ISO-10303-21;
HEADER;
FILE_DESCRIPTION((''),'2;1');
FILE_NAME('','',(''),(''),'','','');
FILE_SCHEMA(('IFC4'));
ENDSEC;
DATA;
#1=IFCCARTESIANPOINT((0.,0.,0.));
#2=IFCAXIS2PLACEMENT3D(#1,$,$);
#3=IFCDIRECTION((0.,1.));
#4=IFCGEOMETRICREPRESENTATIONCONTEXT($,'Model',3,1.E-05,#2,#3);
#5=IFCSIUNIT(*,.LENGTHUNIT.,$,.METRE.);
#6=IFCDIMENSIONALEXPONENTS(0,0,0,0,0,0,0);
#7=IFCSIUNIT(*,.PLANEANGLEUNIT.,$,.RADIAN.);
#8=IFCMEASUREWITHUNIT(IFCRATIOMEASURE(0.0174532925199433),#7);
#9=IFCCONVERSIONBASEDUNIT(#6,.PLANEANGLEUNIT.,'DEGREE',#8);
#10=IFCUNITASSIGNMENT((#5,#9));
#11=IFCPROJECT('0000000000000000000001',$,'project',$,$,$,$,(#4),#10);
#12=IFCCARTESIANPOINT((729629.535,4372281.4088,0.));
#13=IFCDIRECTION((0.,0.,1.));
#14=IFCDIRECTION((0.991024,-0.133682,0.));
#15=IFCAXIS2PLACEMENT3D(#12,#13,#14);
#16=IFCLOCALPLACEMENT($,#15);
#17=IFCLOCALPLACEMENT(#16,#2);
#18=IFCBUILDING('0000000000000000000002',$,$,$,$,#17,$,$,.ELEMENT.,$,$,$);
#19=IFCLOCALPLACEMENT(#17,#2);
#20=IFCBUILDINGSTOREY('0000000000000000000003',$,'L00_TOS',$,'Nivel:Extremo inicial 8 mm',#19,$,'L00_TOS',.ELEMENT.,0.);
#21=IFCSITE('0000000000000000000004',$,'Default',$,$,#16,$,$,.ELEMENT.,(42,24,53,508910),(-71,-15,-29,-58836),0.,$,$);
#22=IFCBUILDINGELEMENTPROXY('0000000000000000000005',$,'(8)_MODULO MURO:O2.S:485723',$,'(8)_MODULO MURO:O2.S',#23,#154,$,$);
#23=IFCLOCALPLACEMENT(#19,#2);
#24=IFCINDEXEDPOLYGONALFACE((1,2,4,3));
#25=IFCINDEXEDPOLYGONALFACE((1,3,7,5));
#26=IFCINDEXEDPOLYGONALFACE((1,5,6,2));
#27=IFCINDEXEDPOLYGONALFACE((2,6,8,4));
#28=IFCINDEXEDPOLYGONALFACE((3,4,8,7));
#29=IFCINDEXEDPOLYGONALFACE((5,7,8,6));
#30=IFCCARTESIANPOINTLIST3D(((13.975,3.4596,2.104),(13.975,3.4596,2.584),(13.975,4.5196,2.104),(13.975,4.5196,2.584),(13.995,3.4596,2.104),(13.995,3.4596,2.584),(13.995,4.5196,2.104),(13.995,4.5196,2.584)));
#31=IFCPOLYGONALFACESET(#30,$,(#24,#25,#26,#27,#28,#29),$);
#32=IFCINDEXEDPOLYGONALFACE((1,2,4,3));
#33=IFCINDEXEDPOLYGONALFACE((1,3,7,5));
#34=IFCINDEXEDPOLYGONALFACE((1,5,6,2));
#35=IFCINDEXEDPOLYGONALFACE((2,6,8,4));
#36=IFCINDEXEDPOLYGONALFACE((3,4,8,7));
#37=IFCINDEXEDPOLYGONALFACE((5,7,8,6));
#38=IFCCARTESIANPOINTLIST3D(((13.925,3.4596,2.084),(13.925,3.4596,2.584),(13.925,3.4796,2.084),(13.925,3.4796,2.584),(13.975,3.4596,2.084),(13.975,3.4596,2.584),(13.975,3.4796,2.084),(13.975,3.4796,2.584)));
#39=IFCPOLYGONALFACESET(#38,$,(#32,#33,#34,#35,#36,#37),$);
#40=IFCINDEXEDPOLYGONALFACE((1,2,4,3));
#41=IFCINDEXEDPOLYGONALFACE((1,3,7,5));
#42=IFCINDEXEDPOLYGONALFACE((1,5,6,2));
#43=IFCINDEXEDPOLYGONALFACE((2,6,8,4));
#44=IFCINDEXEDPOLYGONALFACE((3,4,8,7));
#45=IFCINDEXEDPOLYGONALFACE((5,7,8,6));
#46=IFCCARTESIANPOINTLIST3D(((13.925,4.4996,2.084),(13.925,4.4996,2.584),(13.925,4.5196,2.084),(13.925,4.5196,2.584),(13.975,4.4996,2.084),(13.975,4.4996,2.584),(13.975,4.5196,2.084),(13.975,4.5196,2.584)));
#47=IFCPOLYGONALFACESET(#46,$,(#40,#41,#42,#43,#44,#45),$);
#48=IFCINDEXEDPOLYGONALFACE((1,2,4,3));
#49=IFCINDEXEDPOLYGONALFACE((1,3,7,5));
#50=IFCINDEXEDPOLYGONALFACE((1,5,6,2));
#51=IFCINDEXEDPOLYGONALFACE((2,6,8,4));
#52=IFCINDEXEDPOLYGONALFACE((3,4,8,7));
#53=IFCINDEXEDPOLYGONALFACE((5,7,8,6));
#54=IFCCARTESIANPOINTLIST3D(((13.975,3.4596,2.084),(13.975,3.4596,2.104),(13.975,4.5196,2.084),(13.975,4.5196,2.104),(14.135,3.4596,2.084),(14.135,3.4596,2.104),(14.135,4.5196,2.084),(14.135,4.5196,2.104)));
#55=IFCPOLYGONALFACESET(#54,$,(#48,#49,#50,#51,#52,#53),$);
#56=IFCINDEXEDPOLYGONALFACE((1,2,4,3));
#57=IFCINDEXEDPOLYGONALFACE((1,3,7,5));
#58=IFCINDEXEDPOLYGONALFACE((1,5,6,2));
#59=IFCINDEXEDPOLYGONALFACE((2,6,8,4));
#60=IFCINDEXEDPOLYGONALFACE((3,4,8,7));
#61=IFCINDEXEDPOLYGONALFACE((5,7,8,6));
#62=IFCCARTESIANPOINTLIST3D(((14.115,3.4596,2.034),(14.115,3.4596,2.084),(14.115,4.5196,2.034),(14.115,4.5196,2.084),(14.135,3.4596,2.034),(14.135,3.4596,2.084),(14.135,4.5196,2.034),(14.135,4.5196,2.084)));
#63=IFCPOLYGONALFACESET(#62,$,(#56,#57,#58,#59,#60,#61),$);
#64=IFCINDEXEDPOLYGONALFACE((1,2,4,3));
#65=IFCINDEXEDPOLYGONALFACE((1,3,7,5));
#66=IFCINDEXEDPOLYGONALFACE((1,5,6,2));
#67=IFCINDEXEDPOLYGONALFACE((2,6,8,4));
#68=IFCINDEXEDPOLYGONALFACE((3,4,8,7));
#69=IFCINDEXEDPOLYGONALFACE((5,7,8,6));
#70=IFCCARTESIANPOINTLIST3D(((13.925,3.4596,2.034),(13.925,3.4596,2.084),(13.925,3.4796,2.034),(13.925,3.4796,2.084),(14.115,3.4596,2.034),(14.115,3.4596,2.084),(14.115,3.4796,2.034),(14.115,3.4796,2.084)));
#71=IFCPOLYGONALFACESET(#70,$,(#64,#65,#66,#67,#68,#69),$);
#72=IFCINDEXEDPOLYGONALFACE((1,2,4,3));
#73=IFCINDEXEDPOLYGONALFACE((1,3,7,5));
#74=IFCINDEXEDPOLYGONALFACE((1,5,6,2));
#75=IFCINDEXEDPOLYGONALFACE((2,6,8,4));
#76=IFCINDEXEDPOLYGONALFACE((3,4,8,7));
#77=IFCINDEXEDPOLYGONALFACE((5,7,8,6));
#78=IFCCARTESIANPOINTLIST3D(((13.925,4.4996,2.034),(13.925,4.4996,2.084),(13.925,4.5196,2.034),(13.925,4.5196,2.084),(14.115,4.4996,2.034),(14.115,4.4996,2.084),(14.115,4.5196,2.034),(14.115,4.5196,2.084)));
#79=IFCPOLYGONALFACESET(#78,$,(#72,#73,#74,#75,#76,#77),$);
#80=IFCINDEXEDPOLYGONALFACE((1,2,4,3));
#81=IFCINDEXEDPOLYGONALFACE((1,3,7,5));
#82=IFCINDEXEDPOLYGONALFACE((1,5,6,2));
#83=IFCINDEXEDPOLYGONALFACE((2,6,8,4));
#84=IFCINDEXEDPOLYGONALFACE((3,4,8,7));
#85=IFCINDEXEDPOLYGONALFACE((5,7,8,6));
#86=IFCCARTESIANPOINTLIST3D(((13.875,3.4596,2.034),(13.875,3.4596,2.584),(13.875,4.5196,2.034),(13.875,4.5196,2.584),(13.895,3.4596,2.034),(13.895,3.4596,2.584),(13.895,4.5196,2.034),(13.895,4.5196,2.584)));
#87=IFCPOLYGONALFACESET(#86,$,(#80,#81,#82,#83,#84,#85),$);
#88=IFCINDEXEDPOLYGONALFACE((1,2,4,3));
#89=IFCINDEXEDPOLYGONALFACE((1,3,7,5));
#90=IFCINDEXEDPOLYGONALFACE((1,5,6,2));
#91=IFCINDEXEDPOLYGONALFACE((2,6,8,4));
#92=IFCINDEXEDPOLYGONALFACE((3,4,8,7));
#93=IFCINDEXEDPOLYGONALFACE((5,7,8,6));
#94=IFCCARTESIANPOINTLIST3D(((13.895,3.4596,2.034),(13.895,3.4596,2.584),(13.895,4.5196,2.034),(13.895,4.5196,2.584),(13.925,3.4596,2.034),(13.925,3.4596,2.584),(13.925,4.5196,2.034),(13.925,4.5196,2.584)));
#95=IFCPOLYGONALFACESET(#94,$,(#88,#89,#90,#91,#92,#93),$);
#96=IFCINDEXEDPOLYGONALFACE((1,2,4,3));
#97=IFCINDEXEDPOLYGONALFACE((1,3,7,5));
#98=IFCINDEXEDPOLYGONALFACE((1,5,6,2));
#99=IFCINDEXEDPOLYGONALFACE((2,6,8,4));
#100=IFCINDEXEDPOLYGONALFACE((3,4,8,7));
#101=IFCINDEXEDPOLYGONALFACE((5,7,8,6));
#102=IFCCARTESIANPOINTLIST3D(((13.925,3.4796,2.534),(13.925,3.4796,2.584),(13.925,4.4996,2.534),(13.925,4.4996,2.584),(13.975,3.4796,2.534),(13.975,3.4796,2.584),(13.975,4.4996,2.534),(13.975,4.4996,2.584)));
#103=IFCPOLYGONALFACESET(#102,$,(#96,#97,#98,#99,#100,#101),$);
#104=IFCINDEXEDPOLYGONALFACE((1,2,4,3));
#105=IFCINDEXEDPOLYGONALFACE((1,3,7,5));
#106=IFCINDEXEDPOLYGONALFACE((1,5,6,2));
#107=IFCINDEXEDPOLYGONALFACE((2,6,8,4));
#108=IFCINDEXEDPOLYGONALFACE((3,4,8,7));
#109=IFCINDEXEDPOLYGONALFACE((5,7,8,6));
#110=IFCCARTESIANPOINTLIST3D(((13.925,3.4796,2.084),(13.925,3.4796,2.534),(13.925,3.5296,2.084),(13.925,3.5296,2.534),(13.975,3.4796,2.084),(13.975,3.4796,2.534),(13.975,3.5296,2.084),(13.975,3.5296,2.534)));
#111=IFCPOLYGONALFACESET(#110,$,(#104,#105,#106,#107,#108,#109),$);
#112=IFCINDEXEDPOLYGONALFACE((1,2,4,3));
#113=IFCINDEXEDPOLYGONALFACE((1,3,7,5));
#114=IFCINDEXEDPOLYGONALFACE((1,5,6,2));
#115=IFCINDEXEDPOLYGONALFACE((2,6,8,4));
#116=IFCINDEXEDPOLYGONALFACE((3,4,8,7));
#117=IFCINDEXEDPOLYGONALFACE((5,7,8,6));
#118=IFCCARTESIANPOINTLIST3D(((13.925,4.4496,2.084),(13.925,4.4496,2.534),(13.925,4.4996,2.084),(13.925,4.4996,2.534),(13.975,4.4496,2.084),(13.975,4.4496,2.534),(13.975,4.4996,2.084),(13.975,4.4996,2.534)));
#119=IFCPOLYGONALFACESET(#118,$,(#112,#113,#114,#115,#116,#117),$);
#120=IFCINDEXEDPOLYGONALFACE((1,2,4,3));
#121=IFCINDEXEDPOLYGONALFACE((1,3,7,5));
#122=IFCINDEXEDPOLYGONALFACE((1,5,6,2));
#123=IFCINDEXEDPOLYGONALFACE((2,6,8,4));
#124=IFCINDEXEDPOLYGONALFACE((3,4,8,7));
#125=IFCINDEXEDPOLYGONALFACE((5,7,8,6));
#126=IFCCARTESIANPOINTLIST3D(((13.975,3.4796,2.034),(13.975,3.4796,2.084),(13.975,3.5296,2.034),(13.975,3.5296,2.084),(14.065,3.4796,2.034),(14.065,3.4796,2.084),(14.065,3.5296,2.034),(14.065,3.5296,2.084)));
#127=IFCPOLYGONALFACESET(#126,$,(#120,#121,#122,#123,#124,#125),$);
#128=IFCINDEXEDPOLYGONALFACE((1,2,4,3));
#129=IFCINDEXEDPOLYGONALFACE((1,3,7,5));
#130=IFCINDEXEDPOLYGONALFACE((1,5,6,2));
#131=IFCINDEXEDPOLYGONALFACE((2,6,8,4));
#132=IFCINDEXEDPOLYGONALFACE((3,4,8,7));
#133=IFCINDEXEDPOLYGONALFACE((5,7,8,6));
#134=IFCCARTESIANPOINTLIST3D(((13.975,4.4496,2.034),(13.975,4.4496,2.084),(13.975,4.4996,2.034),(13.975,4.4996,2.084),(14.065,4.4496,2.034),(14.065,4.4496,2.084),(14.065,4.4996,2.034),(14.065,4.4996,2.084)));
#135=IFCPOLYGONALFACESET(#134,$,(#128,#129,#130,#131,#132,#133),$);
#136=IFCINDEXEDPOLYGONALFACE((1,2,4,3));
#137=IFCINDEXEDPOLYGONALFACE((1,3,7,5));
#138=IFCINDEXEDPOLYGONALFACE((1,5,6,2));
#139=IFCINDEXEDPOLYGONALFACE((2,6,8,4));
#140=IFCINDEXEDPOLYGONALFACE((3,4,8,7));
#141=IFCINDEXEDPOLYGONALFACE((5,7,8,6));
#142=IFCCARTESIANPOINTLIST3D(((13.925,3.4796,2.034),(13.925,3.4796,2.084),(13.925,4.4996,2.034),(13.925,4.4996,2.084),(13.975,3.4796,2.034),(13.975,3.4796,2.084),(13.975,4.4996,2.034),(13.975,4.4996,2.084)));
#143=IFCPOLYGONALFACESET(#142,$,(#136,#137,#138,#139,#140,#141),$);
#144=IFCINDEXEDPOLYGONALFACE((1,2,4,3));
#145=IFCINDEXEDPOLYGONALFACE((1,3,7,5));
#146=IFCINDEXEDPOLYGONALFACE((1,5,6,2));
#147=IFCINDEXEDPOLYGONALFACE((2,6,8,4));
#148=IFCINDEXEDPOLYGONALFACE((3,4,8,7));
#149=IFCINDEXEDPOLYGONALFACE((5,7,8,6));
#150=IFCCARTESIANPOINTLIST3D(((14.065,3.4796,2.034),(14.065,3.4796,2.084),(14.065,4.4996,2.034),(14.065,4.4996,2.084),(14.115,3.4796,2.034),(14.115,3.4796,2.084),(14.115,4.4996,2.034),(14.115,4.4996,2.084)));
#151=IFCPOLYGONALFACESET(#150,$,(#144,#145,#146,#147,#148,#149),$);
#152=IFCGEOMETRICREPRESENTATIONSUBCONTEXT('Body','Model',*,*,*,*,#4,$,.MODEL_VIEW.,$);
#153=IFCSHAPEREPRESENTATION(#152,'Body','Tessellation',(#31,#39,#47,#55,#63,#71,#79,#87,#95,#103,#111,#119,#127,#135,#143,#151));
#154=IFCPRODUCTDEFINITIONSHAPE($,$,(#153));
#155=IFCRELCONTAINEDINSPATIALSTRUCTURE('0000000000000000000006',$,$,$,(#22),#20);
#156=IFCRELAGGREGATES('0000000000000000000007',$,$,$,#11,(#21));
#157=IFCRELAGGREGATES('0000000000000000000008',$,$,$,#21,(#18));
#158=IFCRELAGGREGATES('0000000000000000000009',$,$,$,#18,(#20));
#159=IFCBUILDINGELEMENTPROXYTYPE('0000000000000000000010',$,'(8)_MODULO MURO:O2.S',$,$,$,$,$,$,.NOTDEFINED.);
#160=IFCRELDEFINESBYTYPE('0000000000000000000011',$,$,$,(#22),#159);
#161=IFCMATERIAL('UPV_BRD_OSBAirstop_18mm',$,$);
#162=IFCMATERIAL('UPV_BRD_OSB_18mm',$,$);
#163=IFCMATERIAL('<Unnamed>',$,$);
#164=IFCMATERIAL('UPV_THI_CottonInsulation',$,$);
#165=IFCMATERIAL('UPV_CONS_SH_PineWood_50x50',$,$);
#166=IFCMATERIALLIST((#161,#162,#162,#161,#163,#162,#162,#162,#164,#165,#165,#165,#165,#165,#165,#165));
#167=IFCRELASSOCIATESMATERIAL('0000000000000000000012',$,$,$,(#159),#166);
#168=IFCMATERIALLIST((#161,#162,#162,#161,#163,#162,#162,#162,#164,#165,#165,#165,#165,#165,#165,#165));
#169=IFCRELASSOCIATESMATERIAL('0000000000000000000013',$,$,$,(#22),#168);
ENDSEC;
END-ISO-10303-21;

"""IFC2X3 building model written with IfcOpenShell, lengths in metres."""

from ifc_helpers import new_model, entity, si_unit, converted_unit, direction, frame, frame_2d, origin, origin_2d_with_axis, place, context, subcontext, project, spatial, rectangle, extrude, source, transform, mapped, material, material_list, type_object, type_shapes, element, save


model = new_model("IFC2X3")

# Units and contexts
model_context = context("Model", 3, precision=1e-05, world=origin(), true_north=direction((0.0, 1.0)))
body_context = subcontext(model_context, "Body", "Model", "MODEL_VIEW")
ifc_project = project(units=[si_unit("LENGTHUNIT", "METRE"), converted_unit("PLANEANGLEUNIT", "DEGREE", entity("IfcRatioMeasure", 0.0174532925199433), si_unit("PLANEANGLEUNIT", "RADIAN"), dimensions=[0, 0, 0, 0, 0, 0, 0])], contexts=[model_context])

# Site, building, storey
site_placement = place(None, frame((729629.535, 4372281.4088, 0.0), z_axis=(0.0, 0.0, 1.0), x_axis=(0.991024, -0.133682, 0.0)))
site = spatial("IfcSite", under=ifc_project, at=site_placement, Name="Default", CompositionType="ELEMENT", RefLatitude=(42, 24, 53, 508910), RefLongitude=(-71, -15, -29, -58836), RefElevation=0.0)
building_placement = place(site_placement, origin())
building = spatial("IfcBuilding", under=site, at=building_placement, CompositionType="ELEMENT")
storey_placement = place(building_placement, origin())
storey = spatial("IfcBuildingStorey", under=building, at=storey_placement, Name="L00_TOS", ObjectType="Nivel:Extremo inicial 8 mm", LongName="L00_TOS", CompositionType="ELEMENT", Elevation=0.0)

# Building element proxy
ifc_material_1 = material(Name="UPV_BRD_OSBAirstop_18mm")
ifc_material_2 = material(Name="UPV_BRD_OSB_18mm")
ifc_material_3 = material(Name="UPV_THI_CottonInsulation")
ifc_material_4 = material(Name="<Unnamed>")
ifc_material_5 = material(Name="UPV_CONS_SH_PineWood_50x50")
ifc_material_list_1 = material_list([ifc_material_1, ifc_material_2, ifc_material_2, ifc_material_1, ifc_material_4, ifc_material_2, ifc_material_2, ifc_material_2, ifc_material_3, ifc_material_5, ifc_material_5, ifc_material_5, ifc_material_5, ifc_material_5, ifc_material_5, ifc_material_5])
ifc_material_list_2 = material_list([ifc_material_1, ifc_material_2, ifc_material_2, ifc_material_1, ifc_material_4, ifc_material_2, ifc_material_2, ifc_material_2, ifc_material_3, ifc_material_5, ifc_material_5, ifc_material_5, ifc_material_5, ifc_material_5, ifc_material_5, ifc_material_5])
building_element_proxy_type_1 = type_object("IfcBuildingElementProxyType", Name="(8)_MODULO MURO:O2.S", PredefinedType="NOTDEFINED", material=ifc_material_list_2)
shared_shape_1 = source(origin(), body_context, "Body", "SweptSolid", [
    extrude(rectangle(XDim=1.06, YDim=0.02, at=frame_2d((0.0, 0.0), x_axis=(1.0, 0.0))), frame((0.0, 0.035, 0.07), z_axis=(0.0, 0.0, 1.0), x_axis=(-1.0, 0.0, 0.0)), (0.0, 0.0, 1.0), 0.48),
    extrude(rectangle(XDim=0.05, YDim=0.02, at=frame_2d((0.0, 0.0), x_axis=(1.0, 0.0))), frame((-0.52, 0.07, 0.05), z_axis=(0.0, 0.0, 1.0), x_axis=(0.0, -1.0, 0.0)), (0.0, 0.0, 1.0), 0.5),
    extrude(rectangle(XDim=0.05, YDim=0.02, at=origin_2d_with_axis()), frame((0.52, 0.07, 0.05), z_axis=(0.0, 0.0, 1.0), x_axis=(0.0, -1.0, 0.0)), (0.0, 0.0, 1.0), 0.5),
    extrude(rectangle(XDim=1.06, YDim=0.16, at=origin_2d_with_axis()), frame((0.0, -0.035, 0.05)), (0.0, 0.0, 1.0), 0.02),
    extrude(rectangle(XDim=1.06, YDim=0.02, at=origin_2d_with_axis()), frame((0.0, -0.105, 0.0), z_axis=(0.0, 0.0, 1.0), x_axis=(-1.0, 0.0, 0.0)), (0.0, 0.0, 1.0), 0.05),
    extrude(rectangle(XDim=0.19, YDim=0.02, at=origin_2d_with_axis()), frame((-0.52, 0.0, 0.0), z_axis=(0.0, 0.0, 1.0), x_axis=(0.0, -1.0, 0.0)), (0.0, 0.0, 1.0), 0.05),
    extrude(rectangle(XDim=0.19, YDim=0.02, at=origin_2d_with_axis()), frame((0.52, 0.0, 0.0), z_axis=(0.0, 0.0, 1.0), x_axis=(0.0, -1.0, 0.0)), (0.0, 0.0, 1.0), 0.05),
    extrude(rectangle(XDim=1.06, YDim=0.02, at=frame_2d((0.0, 0.0), x_axis=(1.0, 0.0))), frame((0.0, 0.135, 0.0), z_axis=(0.0, 0.0, 1.0), x_axis=(-1.0, 0.0, 0.0)), (0.0, 0.0, 1.0), 0.55),
    extrude(rectangle(XDim=1.06, YDim=0.03, at=origin_2d_with_axis()), frame((0.0, 0.11, 0.0)), (0.0, 0.0, 1.0), 0.55),
    extrude(rectangle(XDim=0.05, YDim=1.02, at=origin_2d_with_axis()), frame((0.0, 0.07, 0.5), z_axis=(0.0, 0.0, 1.0), x_axis=(0.0, -1.0, 0.0)), (0.0, 0.0, 1.0), 0.05),
    extrude(rectangle(XDim=0.05, YDim=0.05, at=origin_2d_with_axis()), frame((-0.485, 0.07, 0.05)), (0.0, 0.0, 1.0), 0.45),
    extrude(rectangle(XDim=0.05, YDim=0.05, at=origin_2d_with_axis()), frame((0.485, 0.07, 0.05), z_axis=(0.0, 0.0, 1.0), x_axis=(0.0, -1.0, 0.0)), (0.0, 0.0, 1.0), 0.45),
    extrude(rectangle(XDim=0.09, YDim=0.05, at=frame_2d((0.0, 0.0), x_axis=(1.0, 0.0))), frame((-0.485, 0.0, 0.0), z_axis=(0.0, 0.0, 1.0), x_axis=(0.0, -1.0, 0.0)), (0.0, 0.0, 1.0), 0.05),
    extrude(rectangle(XDim=0.09, YDim=0.05, at=origin_2d_with_axis()), frame((0.485, 0.0, 0.0), z_axis=(0.0, 0.0, 1.0), x_axis=(0.0, -1.0, 0.0)), (0.0, 0.0, 1.0), 0.05),
    extrude(rectangle(XDim=0.05, YDim=1.02, at=origin_2d_with_axis()), frame((0.0, 0.07, 0.0), z_axis=(0.0, 0.0, 1.0), x_axis=(0.0, -1.0, 0.0)), (0.0, 0.0, 1.0), 0.05),
    extrude(rectangle(XDim=0.05, YDim=1.02, at=origin_2d_with_axis()), frame((0.0, -0.07, 0.0), z_axis=(0.0, 0.0, 1.0), x_axis=(0.0, -1.0, 0.0)), (0.0, 0.0, 1.0), 0.05),
])
type_shapes(building_element_proxy_type_1, [shared_shape_1])
proxy_1_placement = place(storey_placement, frame((14.02, 3.9896, 2.034), z_axis=(0.0, 0.0, 1.0), x_axis=(0.0, 1.0, 0.0)))
element("IfcBuildingElementProxy", 1, at=proxy_1_placement, inside=storey, type_object=building_element_proxy_type_1, material=ifc_material_list_1, Name="(8)_MODULO MURO:O2.S:485723", ObjectType="(8)_MODULO MURO:O2.S", context=body_context, shape_type="MappedRepresentation", body=[
    mapped(shared_shape_1, transform((0.0, 0.0, 0.0), scale=1.0)),
])

save(model, "model.ifc")
